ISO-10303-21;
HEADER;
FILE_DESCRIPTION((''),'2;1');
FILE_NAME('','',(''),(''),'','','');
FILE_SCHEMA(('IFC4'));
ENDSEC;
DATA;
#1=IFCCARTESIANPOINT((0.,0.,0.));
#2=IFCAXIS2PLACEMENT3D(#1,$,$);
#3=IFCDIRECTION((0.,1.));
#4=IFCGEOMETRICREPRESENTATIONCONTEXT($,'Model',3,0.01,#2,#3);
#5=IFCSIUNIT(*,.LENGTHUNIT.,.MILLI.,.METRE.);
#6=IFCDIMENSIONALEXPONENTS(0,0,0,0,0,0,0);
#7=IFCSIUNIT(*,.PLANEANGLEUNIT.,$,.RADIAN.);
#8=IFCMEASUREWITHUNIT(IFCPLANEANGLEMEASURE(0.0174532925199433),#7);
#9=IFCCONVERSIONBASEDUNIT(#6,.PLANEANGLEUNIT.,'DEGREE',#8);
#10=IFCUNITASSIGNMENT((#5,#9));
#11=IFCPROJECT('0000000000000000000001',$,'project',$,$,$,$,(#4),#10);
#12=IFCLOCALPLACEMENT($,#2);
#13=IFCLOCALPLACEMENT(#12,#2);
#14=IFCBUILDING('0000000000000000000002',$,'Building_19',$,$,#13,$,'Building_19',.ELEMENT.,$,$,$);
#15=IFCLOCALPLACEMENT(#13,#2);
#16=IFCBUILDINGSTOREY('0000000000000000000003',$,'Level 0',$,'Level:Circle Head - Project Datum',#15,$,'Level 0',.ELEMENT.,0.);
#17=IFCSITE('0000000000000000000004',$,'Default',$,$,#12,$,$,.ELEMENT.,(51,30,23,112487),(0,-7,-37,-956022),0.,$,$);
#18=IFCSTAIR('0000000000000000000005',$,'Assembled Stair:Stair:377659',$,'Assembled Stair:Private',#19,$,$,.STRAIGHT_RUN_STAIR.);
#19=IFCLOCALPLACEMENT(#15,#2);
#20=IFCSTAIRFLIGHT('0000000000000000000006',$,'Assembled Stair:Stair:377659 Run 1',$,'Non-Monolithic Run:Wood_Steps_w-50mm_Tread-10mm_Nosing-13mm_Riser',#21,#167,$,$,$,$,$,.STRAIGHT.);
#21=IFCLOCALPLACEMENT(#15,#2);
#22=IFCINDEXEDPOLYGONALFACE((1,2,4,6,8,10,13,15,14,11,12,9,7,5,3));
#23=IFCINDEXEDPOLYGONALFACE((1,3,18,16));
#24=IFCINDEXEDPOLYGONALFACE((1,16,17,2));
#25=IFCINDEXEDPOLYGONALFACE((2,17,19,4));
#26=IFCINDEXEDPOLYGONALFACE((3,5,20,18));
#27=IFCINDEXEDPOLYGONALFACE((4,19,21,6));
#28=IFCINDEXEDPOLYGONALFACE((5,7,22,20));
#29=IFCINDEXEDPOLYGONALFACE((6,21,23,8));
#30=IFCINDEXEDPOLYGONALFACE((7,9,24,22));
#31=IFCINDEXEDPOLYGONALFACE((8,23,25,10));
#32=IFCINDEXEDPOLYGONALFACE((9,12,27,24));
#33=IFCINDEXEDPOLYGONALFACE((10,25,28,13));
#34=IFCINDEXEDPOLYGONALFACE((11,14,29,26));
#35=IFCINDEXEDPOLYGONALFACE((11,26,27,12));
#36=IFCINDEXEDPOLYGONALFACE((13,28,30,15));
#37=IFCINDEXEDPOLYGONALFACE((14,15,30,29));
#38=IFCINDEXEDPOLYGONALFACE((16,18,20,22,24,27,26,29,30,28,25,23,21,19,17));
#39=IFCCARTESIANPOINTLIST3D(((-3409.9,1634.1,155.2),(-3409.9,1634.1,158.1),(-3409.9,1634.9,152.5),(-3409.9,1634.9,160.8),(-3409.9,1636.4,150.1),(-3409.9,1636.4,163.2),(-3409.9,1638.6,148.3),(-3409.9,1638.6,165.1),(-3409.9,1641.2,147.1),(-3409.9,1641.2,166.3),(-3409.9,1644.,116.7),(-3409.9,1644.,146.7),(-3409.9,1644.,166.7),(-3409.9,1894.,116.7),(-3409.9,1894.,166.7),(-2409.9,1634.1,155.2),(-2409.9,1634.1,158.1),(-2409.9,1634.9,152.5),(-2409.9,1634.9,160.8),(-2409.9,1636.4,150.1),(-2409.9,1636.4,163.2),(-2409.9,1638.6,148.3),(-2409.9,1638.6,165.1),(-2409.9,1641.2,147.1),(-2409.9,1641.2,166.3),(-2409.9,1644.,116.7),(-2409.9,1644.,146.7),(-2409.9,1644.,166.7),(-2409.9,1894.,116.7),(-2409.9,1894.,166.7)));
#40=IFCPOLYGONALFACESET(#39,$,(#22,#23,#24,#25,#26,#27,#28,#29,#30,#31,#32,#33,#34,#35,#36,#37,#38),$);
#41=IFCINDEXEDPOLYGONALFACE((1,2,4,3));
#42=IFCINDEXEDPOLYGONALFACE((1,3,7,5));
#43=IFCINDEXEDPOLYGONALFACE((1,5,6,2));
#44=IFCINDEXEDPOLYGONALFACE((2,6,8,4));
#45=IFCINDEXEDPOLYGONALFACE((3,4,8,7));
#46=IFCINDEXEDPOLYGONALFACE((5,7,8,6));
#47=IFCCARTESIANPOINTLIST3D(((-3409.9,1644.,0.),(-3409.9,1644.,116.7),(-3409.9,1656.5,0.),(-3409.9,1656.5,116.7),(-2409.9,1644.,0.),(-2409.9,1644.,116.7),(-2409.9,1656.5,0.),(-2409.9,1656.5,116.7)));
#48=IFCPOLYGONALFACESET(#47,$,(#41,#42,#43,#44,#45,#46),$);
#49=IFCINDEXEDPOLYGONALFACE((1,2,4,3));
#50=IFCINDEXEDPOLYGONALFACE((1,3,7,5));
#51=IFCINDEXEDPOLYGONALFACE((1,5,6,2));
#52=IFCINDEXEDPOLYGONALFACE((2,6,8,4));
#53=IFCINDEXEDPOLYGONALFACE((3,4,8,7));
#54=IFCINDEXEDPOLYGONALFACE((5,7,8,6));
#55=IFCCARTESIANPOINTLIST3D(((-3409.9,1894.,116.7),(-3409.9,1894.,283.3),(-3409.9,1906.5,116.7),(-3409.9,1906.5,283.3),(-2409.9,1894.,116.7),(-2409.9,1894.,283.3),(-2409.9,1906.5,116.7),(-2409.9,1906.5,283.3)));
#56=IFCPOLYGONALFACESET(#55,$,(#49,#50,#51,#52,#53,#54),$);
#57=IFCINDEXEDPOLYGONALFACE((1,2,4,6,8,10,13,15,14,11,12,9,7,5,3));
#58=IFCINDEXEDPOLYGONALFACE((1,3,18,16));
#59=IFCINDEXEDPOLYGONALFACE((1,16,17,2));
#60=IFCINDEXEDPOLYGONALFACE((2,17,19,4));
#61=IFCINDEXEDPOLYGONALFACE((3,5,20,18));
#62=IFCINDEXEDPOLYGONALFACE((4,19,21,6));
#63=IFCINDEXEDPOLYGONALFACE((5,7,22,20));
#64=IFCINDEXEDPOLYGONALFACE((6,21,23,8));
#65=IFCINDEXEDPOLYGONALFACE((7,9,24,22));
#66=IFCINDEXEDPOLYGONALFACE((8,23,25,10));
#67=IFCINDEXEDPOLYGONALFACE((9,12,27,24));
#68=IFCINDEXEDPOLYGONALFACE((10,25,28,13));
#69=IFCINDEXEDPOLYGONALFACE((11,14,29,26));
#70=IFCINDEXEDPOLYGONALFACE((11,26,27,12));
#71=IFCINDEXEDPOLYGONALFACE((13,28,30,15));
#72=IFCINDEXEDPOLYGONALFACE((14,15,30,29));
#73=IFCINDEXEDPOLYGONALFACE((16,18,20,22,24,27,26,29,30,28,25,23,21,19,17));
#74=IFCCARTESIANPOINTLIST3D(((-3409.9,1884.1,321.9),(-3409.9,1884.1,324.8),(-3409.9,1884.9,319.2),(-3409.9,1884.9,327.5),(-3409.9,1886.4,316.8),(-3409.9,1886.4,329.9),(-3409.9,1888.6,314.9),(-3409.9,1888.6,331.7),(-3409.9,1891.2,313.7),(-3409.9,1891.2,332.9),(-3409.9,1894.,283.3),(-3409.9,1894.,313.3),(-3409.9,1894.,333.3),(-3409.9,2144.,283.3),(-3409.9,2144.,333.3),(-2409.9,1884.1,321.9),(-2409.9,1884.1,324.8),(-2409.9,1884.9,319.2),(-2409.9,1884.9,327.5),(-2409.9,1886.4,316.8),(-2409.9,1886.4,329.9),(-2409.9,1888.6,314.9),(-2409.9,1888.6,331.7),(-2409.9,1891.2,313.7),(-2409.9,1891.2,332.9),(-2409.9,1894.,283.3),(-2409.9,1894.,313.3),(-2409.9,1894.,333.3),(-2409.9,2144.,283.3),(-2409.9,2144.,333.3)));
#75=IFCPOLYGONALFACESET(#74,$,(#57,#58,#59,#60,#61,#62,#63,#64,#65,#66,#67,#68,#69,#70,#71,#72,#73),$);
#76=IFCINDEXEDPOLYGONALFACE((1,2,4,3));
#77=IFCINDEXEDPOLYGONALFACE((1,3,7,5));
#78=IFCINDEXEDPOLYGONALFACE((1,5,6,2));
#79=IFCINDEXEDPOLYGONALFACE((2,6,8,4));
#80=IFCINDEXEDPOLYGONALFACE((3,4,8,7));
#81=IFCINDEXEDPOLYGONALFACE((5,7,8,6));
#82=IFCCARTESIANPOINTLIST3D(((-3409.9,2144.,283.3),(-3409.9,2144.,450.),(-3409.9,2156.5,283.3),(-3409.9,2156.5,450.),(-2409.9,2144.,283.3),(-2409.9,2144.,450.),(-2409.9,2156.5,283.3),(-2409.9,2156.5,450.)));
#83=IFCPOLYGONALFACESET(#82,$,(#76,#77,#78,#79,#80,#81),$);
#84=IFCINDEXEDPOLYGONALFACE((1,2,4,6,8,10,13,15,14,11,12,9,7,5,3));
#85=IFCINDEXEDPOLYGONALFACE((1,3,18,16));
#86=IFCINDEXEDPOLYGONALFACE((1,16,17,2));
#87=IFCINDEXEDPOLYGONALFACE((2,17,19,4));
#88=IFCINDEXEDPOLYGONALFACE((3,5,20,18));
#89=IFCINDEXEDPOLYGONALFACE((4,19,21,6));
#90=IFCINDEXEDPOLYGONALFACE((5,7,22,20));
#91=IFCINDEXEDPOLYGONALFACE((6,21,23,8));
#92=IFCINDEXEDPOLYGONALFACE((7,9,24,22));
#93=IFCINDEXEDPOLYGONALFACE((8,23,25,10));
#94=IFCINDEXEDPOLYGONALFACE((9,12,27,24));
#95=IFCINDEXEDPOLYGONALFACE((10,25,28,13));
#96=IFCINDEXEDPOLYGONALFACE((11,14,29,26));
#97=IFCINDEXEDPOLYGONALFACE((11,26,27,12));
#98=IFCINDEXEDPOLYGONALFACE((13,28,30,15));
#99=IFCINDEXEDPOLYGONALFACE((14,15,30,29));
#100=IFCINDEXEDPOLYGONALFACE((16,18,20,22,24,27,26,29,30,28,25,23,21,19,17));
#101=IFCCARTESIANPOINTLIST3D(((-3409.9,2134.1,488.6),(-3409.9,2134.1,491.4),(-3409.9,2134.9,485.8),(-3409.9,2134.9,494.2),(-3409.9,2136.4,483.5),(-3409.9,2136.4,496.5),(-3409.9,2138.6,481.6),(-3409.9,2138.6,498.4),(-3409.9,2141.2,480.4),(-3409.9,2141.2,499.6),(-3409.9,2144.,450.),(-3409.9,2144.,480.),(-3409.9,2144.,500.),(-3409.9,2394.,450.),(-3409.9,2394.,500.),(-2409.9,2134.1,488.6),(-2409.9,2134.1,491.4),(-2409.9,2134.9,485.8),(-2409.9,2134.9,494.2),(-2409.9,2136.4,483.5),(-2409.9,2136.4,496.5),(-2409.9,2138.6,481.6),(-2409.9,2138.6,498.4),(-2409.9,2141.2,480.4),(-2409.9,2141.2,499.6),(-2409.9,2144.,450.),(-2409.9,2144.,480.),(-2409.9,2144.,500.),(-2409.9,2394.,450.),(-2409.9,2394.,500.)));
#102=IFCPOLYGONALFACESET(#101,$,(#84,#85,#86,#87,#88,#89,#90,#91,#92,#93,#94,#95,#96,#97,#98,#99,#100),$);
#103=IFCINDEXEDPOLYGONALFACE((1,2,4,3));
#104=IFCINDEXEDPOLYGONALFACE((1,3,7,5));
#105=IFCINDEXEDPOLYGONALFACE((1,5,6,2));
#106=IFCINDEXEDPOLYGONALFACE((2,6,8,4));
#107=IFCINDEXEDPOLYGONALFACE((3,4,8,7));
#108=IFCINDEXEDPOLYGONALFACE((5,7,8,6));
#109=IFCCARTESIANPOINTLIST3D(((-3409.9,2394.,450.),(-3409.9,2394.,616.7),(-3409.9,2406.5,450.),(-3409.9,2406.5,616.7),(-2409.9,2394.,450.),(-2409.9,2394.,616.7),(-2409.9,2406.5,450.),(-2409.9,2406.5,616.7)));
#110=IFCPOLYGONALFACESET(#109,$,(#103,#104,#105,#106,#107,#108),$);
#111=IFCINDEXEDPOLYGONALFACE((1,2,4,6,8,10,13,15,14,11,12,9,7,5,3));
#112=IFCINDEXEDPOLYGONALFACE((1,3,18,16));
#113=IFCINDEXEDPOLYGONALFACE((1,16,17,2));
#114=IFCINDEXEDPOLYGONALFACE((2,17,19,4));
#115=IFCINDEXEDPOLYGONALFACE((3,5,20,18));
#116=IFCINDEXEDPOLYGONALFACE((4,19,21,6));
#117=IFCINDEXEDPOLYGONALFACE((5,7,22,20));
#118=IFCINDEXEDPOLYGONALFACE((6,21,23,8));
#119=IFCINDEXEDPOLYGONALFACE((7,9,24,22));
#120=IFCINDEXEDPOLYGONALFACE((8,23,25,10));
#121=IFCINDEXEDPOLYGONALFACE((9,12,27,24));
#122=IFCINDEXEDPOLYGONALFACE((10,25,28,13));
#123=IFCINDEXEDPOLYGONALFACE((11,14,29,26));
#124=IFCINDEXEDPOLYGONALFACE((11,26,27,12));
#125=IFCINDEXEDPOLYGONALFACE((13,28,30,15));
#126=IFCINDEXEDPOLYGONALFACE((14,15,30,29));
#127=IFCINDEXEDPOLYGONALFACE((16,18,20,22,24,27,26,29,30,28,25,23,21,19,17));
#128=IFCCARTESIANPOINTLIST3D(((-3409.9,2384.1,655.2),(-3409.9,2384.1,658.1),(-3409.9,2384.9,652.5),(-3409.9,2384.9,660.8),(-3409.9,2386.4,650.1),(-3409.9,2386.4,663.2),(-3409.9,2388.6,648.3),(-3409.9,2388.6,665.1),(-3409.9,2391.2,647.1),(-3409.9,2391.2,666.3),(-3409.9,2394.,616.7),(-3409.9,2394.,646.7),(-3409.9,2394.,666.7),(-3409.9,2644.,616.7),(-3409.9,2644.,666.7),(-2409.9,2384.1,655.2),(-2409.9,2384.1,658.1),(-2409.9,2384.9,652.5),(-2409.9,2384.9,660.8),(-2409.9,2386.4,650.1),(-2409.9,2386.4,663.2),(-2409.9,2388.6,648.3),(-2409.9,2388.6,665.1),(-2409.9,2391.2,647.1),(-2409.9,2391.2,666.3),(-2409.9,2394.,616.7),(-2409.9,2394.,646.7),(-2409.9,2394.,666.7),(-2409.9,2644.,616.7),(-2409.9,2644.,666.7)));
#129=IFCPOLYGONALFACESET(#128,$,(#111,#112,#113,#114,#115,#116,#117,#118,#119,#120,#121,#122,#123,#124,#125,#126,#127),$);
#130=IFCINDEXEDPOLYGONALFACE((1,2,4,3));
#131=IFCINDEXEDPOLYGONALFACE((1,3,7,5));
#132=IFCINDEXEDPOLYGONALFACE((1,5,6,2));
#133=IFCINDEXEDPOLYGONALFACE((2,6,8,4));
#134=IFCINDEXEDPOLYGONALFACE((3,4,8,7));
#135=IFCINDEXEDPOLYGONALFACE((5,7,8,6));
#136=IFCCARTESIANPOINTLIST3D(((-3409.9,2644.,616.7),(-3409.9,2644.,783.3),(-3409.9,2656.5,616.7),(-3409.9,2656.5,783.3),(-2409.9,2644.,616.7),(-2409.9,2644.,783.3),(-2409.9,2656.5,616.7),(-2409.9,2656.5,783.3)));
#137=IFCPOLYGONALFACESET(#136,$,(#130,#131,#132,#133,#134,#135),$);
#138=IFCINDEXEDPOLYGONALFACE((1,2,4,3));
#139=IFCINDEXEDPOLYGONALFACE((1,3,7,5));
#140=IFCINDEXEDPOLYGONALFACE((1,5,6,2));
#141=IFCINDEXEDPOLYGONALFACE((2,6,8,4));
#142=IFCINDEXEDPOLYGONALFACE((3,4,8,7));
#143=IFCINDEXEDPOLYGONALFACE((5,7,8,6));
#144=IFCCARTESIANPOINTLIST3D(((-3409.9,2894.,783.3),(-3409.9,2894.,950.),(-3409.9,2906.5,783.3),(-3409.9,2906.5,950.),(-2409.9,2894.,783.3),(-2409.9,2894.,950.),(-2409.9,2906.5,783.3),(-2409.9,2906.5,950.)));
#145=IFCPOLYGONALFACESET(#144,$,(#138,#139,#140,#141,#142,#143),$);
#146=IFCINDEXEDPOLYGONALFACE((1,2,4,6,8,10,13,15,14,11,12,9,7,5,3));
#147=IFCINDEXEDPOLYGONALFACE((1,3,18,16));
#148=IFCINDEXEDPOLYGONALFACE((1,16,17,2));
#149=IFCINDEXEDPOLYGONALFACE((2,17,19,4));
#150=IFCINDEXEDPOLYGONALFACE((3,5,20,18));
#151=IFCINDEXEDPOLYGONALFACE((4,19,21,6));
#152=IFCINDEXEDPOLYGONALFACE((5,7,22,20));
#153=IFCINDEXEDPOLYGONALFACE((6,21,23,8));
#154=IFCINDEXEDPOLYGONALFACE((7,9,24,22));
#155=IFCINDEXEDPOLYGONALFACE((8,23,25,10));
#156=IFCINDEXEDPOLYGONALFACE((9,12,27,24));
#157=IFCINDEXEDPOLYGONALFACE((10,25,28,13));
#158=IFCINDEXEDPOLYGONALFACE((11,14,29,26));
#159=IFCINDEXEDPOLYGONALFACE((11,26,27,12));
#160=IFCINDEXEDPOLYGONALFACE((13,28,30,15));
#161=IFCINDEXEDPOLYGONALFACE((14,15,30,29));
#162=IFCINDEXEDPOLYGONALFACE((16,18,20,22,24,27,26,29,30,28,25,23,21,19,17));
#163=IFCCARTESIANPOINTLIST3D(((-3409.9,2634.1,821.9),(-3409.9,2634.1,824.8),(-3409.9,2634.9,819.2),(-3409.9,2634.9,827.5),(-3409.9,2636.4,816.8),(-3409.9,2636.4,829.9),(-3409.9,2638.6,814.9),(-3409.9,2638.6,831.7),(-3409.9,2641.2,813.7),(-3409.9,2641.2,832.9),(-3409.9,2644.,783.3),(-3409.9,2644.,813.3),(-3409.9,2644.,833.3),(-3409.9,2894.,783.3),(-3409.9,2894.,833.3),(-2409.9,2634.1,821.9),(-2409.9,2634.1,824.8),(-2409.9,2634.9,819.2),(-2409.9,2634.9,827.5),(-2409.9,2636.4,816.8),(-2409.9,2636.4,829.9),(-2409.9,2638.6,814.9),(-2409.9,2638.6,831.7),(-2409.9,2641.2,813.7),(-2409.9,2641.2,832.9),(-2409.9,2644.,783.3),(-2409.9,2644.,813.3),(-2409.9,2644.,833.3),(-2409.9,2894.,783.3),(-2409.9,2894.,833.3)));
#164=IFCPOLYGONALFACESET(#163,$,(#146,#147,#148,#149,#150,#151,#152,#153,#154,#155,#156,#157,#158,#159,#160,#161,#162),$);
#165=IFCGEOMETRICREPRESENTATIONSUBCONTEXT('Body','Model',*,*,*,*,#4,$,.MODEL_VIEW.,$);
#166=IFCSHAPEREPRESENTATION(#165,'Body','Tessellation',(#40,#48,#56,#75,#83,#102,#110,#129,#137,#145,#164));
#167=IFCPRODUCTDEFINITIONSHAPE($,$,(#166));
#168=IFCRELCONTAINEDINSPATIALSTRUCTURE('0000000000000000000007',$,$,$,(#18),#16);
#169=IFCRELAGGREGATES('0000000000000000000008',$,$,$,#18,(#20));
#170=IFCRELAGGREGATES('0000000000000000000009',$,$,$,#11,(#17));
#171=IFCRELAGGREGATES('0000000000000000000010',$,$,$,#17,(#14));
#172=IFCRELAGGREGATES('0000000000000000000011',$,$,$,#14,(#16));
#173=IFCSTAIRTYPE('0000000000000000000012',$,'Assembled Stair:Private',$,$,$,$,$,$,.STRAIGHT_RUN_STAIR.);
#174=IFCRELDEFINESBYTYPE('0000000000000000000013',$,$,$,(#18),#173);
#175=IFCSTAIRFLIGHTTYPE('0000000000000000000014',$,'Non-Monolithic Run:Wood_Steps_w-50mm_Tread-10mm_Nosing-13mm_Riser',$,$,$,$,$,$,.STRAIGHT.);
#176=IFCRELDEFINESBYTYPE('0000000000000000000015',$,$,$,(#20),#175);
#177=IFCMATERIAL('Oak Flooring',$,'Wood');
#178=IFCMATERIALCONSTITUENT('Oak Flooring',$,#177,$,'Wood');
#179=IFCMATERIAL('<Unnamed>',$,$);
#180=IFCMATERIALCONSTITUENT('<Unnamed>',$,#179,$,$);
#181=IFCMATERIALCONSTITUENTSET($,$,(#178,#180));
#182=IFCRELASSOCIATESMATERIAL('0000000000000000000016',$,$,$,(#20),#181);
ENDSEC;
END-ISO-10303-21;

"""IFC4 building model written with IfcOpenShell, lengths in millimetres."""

from ifc_helpers import new_model, entity, si_unit, converted_unit, direction, frame, origin, place, context, subcontext, project, spatial, line, arc, indexed_curve, outline, extrude, material, constituent, constituent_set, type_object, element, aggregate, save


model = new_model("IFC4")

# Units and contexts
model_context = context("Model", 3, precision=0.01, world=origin(), true_north=direction((0.0, 1.0)))
body_context = subcontext(model_context, "Body", "Model", "MODEL_VIEW")
ifc_project = project(units=[si_unit("LENGTHUNIT", "METRE", prefix="MILLI"), converted_unit("PLANEANGLEUNIT", "DEGREE", entity("IfcPlaneAngleMeasure", 0.0174532925199433), si_unit("PLANEANGLEUNIT", "RADIAN"), dimensions=[0, 0, 0, 0, 0, 0, 0])], contexts=[model_context])

# Site, building, storey
site_placement = place(None, origin())
site = spatial("IfcSite", under=ifc_project, at=site_placement, Name="Default", CompositionType="ELEMENT", RefLatitude=(51, 30, 23, 112487), RefLongitude=(0, -7, -37, -956022), RefElevation=0.0)
building_placement = place(site_placement, origin())
building = spatial("IfcBuilding", under=site, at=building_placement, Name="Building_19", LongName="Building_19", CompositionType="ELEMENT")
storey_placement = place(building_placement, origin())
storey = spatial("IfcBuildingStorey", under=building, at=storey_placement, Name="Level 0", ObjectType="Level:Circle Head - Project Datum", LongName="Level 0", CompositionType="ELEMENT", Elevation=0.0)

# Stair
stair_type = type_object("IfcStairType", Name="Assembled Stair:Private", PredefinedType="STRAIGHT_RUN_STAIR")
ifc_material_1 = material(Name="<Unnamed>")
stair_1_placement = place(storey_placement, origin())
stair_1 = element("IfcStair", 1, at=stair_1_placement, inside=storey, type_object=stair_type, Name="Assembled Stair:Stair:377659", ObjectType="Assembled Stair:Private", PredefinedType="STRAIGHT_RUN_STAIR")

# Stair flight
ifc_material_2 = material(Name="Oak Flooring", Category="Wood")
stair_flight_type = type_object("IfcStairFlightType", Name="Non-Monolithic Run:Wood_Steps_w-50mm_Tread-10mm_Nosing-13mm_Riser", PredefinedType="STRAIGHT")
ifc_constituent_1 = constituent(ifc_material_2, Name="Oak Flooring", Category="Wood")
ifc_constituent_2 = constituent(ifc_material_1, Name="<Unnamed>")
ifc_constituent_set_1 = constituent_set(constituents=[ifc_constituent_1, ifc_constituent_2])
stair_flight_1_placement = place(stair_1_placement, origin())
stair_flight_1 = element("IfcStairFlight", 2, at=stair_flight_1_placement, type_object=stair_flight_type, material=ifc_constituent_set_1, Name="Assembled Stair:Stair:377659 Run 1", ObjectType="Non-Monolithic Run:Wood_Steps_w-50mm_Tread-10mm_Nosing-13mm_Riser", PredefinedType="STRAIGHT", context=body_context, shape_type="SweptSolid", body=[
    extrude(outline(indexed_curve([(-100.0, 24.0), (-110.0, 14.0), (-100.0, 4.0), (-100.0, -26.0), (150.0, -26.0), (150.0, 24.0)], segments=[arc(1, 2, 3), line(3, 4, 5, 6, 1)], self_intersect=False)), frame((-3409.9, 1744.0, 142.7), z_axis=(1.0, 0.0, 0.0), x_axis=(0.0, 1.0, 0.0)), (0.0, 0.0, 1.0), 1000.0),
    extrude(outline(indexed_curve([(-500.0, -6.2), (500.0, -6.2), (500.0, 6.3), (-500.0, 6.3), (-500.0, -6.2)], self_intersect=False)), frame((-2909.9, 1650.2, 0.0), z_axis=(0.0, 0.0, 1.0), x_axis=(-1.0, 0.0, 0.0)), (0.0, 0.0, 1.0), 116.7),
    extrude(outline(indexed_curve([(-500.0, -6.2), (500.0, -6.2), (500.0, 6.3), (-500.0, 6.3), (-500.0, -6.2)], self_intersect=False)), frame((-2909.9, 1900.2, 116.7), z_axis=(0.0, 0.0, 1.0), x_axis=(-1.0, 0.0, 0.0)), (0.0, 0.0, 1.0), 166.7),
    extrude(outline(indexed_curve([(-100.0, 24.0), (-110.0, 14.0), (-100.0, 4.0), (-100.0, -26.0), (150.0, -26.0), (150.0, 24.0)], segments=[arc(1, 2, 3), line(3, 4, 5, 6, 1)], self_intersect=False)), frame((-3409.9, 1994.0, 309.3), z_axis=(1.0, 0.0, 0.0), x_axis=(0.0, 1.0, 0.0)), (0.0, 0.0, 1.0), 1000.0),
    extrude(outline(indexed_curve([(-500.0, -6.3), (500.0, -6.3), (500.0, 6.2), (-500.0, 6.2), (-500.0, -6.3)], self_intersect=False)), frame((-2909.9, 2150.2, 283.3), z_axis=(0.0, 0.0, 1.0), x_axis=(-1.0, 0.0, 0.0)), (0.0, 0.0, 1.0), 166.7),
    extrude(outline(indexed_curve([(-100.0, 24.0), (-110.0, 14.0), (-100.0, 4.0), (-100.0, -26.0), (150.0, -26.0), (150.0, 24.0)], segments=[arc(1, 2, 3), line(3, 4, 5, 6, 1)], self_intersect=False)), frame((-3409.9, 2244.0, 476.0), z_axis=(1.0, 0.0, 0.0), x_axis=(0.0, 1.0, 0.0)), (0.0, 0.0, 1.0), 1000.0),
    extrude(outline(indexed_curve([(-500.0, -6.3), (500.0, -6.3), (500.0, 6.2), (-500.0, 6.2), (-500.0, -6.3)], self_intersect=False)), frame((-2909.9, 2400.2, 450.0), z_axis=(0.0, 0.0, 1.0), x_axis=(-1.0, 0.0, 0.0)), (0.0, 0.0, 1.0), 166.7),
    extrude(outline(indexed_curve([(-100.0, 24.0), (-110.0, 14.0), (-100.0, 4.0), (-100.0, -26.0), (150.0, -26.0), (150.0, 24.0)], segments=[arc(1, 2, 3), line(3, 4, 5, 6, 1)], self_intersect=False)), frame((-3409.9, 2494.0, 642.7), z_axis=(1.0, 0.0, 0.0), x_axis=(0.0, 1.0, 0.0)), (0.0, 0.0, 1.0), 1000.0),
    extrude(outline(indexed_curve([(-500.0, -6.3), (500.0, -6.3), (500.0, 6.3), (-500.0, 6.3), (-500.0, -6.3)], self_intersect=False)), frame((-2909.9, 2650.2, 616.7), z_axis=(0.0, 0.0, 1.0), x_axis=(-1.0, 0.0, 0.0)), (0.0, 0.0, 1.0), 166.7),
    extrude(outline(indexed_curve([(-500.0, -6.3), (500.0, -6.3), (500.0, 6.2), (-500.0, 6.2), (-500.0, -6.3)], self_intersect=False)), frame((-2909.9, 2900.2, 783.3), z_axis=(0.0, 0.0, 1.0), x_axis=(-1.0, 0.0, 0.0)), (0.0, 0.0, 1.0), 166.7),
    extrude(outline(indexed_curve([(-100.0, 24.0), (-110.0, 14.0), (-100.0, 4.0), (-100.0, -26.0), (150.0, -26.0), (150.0, 24.0)], segments=[arc(1, 2, 3), line(3, 4, 5, 6, 1)], self_intersect=False)), frame((-3409.9, 2744.0, 809.3), z_axis=(1.0, 0.0, 0.0), x_axis=(0.0, 1.0, 0.0)), (0.0, 0.0, 1.0), 1000.0),
])
aggregate(stair_1, [stair_flight_1])

save(model, "model.ifc")
